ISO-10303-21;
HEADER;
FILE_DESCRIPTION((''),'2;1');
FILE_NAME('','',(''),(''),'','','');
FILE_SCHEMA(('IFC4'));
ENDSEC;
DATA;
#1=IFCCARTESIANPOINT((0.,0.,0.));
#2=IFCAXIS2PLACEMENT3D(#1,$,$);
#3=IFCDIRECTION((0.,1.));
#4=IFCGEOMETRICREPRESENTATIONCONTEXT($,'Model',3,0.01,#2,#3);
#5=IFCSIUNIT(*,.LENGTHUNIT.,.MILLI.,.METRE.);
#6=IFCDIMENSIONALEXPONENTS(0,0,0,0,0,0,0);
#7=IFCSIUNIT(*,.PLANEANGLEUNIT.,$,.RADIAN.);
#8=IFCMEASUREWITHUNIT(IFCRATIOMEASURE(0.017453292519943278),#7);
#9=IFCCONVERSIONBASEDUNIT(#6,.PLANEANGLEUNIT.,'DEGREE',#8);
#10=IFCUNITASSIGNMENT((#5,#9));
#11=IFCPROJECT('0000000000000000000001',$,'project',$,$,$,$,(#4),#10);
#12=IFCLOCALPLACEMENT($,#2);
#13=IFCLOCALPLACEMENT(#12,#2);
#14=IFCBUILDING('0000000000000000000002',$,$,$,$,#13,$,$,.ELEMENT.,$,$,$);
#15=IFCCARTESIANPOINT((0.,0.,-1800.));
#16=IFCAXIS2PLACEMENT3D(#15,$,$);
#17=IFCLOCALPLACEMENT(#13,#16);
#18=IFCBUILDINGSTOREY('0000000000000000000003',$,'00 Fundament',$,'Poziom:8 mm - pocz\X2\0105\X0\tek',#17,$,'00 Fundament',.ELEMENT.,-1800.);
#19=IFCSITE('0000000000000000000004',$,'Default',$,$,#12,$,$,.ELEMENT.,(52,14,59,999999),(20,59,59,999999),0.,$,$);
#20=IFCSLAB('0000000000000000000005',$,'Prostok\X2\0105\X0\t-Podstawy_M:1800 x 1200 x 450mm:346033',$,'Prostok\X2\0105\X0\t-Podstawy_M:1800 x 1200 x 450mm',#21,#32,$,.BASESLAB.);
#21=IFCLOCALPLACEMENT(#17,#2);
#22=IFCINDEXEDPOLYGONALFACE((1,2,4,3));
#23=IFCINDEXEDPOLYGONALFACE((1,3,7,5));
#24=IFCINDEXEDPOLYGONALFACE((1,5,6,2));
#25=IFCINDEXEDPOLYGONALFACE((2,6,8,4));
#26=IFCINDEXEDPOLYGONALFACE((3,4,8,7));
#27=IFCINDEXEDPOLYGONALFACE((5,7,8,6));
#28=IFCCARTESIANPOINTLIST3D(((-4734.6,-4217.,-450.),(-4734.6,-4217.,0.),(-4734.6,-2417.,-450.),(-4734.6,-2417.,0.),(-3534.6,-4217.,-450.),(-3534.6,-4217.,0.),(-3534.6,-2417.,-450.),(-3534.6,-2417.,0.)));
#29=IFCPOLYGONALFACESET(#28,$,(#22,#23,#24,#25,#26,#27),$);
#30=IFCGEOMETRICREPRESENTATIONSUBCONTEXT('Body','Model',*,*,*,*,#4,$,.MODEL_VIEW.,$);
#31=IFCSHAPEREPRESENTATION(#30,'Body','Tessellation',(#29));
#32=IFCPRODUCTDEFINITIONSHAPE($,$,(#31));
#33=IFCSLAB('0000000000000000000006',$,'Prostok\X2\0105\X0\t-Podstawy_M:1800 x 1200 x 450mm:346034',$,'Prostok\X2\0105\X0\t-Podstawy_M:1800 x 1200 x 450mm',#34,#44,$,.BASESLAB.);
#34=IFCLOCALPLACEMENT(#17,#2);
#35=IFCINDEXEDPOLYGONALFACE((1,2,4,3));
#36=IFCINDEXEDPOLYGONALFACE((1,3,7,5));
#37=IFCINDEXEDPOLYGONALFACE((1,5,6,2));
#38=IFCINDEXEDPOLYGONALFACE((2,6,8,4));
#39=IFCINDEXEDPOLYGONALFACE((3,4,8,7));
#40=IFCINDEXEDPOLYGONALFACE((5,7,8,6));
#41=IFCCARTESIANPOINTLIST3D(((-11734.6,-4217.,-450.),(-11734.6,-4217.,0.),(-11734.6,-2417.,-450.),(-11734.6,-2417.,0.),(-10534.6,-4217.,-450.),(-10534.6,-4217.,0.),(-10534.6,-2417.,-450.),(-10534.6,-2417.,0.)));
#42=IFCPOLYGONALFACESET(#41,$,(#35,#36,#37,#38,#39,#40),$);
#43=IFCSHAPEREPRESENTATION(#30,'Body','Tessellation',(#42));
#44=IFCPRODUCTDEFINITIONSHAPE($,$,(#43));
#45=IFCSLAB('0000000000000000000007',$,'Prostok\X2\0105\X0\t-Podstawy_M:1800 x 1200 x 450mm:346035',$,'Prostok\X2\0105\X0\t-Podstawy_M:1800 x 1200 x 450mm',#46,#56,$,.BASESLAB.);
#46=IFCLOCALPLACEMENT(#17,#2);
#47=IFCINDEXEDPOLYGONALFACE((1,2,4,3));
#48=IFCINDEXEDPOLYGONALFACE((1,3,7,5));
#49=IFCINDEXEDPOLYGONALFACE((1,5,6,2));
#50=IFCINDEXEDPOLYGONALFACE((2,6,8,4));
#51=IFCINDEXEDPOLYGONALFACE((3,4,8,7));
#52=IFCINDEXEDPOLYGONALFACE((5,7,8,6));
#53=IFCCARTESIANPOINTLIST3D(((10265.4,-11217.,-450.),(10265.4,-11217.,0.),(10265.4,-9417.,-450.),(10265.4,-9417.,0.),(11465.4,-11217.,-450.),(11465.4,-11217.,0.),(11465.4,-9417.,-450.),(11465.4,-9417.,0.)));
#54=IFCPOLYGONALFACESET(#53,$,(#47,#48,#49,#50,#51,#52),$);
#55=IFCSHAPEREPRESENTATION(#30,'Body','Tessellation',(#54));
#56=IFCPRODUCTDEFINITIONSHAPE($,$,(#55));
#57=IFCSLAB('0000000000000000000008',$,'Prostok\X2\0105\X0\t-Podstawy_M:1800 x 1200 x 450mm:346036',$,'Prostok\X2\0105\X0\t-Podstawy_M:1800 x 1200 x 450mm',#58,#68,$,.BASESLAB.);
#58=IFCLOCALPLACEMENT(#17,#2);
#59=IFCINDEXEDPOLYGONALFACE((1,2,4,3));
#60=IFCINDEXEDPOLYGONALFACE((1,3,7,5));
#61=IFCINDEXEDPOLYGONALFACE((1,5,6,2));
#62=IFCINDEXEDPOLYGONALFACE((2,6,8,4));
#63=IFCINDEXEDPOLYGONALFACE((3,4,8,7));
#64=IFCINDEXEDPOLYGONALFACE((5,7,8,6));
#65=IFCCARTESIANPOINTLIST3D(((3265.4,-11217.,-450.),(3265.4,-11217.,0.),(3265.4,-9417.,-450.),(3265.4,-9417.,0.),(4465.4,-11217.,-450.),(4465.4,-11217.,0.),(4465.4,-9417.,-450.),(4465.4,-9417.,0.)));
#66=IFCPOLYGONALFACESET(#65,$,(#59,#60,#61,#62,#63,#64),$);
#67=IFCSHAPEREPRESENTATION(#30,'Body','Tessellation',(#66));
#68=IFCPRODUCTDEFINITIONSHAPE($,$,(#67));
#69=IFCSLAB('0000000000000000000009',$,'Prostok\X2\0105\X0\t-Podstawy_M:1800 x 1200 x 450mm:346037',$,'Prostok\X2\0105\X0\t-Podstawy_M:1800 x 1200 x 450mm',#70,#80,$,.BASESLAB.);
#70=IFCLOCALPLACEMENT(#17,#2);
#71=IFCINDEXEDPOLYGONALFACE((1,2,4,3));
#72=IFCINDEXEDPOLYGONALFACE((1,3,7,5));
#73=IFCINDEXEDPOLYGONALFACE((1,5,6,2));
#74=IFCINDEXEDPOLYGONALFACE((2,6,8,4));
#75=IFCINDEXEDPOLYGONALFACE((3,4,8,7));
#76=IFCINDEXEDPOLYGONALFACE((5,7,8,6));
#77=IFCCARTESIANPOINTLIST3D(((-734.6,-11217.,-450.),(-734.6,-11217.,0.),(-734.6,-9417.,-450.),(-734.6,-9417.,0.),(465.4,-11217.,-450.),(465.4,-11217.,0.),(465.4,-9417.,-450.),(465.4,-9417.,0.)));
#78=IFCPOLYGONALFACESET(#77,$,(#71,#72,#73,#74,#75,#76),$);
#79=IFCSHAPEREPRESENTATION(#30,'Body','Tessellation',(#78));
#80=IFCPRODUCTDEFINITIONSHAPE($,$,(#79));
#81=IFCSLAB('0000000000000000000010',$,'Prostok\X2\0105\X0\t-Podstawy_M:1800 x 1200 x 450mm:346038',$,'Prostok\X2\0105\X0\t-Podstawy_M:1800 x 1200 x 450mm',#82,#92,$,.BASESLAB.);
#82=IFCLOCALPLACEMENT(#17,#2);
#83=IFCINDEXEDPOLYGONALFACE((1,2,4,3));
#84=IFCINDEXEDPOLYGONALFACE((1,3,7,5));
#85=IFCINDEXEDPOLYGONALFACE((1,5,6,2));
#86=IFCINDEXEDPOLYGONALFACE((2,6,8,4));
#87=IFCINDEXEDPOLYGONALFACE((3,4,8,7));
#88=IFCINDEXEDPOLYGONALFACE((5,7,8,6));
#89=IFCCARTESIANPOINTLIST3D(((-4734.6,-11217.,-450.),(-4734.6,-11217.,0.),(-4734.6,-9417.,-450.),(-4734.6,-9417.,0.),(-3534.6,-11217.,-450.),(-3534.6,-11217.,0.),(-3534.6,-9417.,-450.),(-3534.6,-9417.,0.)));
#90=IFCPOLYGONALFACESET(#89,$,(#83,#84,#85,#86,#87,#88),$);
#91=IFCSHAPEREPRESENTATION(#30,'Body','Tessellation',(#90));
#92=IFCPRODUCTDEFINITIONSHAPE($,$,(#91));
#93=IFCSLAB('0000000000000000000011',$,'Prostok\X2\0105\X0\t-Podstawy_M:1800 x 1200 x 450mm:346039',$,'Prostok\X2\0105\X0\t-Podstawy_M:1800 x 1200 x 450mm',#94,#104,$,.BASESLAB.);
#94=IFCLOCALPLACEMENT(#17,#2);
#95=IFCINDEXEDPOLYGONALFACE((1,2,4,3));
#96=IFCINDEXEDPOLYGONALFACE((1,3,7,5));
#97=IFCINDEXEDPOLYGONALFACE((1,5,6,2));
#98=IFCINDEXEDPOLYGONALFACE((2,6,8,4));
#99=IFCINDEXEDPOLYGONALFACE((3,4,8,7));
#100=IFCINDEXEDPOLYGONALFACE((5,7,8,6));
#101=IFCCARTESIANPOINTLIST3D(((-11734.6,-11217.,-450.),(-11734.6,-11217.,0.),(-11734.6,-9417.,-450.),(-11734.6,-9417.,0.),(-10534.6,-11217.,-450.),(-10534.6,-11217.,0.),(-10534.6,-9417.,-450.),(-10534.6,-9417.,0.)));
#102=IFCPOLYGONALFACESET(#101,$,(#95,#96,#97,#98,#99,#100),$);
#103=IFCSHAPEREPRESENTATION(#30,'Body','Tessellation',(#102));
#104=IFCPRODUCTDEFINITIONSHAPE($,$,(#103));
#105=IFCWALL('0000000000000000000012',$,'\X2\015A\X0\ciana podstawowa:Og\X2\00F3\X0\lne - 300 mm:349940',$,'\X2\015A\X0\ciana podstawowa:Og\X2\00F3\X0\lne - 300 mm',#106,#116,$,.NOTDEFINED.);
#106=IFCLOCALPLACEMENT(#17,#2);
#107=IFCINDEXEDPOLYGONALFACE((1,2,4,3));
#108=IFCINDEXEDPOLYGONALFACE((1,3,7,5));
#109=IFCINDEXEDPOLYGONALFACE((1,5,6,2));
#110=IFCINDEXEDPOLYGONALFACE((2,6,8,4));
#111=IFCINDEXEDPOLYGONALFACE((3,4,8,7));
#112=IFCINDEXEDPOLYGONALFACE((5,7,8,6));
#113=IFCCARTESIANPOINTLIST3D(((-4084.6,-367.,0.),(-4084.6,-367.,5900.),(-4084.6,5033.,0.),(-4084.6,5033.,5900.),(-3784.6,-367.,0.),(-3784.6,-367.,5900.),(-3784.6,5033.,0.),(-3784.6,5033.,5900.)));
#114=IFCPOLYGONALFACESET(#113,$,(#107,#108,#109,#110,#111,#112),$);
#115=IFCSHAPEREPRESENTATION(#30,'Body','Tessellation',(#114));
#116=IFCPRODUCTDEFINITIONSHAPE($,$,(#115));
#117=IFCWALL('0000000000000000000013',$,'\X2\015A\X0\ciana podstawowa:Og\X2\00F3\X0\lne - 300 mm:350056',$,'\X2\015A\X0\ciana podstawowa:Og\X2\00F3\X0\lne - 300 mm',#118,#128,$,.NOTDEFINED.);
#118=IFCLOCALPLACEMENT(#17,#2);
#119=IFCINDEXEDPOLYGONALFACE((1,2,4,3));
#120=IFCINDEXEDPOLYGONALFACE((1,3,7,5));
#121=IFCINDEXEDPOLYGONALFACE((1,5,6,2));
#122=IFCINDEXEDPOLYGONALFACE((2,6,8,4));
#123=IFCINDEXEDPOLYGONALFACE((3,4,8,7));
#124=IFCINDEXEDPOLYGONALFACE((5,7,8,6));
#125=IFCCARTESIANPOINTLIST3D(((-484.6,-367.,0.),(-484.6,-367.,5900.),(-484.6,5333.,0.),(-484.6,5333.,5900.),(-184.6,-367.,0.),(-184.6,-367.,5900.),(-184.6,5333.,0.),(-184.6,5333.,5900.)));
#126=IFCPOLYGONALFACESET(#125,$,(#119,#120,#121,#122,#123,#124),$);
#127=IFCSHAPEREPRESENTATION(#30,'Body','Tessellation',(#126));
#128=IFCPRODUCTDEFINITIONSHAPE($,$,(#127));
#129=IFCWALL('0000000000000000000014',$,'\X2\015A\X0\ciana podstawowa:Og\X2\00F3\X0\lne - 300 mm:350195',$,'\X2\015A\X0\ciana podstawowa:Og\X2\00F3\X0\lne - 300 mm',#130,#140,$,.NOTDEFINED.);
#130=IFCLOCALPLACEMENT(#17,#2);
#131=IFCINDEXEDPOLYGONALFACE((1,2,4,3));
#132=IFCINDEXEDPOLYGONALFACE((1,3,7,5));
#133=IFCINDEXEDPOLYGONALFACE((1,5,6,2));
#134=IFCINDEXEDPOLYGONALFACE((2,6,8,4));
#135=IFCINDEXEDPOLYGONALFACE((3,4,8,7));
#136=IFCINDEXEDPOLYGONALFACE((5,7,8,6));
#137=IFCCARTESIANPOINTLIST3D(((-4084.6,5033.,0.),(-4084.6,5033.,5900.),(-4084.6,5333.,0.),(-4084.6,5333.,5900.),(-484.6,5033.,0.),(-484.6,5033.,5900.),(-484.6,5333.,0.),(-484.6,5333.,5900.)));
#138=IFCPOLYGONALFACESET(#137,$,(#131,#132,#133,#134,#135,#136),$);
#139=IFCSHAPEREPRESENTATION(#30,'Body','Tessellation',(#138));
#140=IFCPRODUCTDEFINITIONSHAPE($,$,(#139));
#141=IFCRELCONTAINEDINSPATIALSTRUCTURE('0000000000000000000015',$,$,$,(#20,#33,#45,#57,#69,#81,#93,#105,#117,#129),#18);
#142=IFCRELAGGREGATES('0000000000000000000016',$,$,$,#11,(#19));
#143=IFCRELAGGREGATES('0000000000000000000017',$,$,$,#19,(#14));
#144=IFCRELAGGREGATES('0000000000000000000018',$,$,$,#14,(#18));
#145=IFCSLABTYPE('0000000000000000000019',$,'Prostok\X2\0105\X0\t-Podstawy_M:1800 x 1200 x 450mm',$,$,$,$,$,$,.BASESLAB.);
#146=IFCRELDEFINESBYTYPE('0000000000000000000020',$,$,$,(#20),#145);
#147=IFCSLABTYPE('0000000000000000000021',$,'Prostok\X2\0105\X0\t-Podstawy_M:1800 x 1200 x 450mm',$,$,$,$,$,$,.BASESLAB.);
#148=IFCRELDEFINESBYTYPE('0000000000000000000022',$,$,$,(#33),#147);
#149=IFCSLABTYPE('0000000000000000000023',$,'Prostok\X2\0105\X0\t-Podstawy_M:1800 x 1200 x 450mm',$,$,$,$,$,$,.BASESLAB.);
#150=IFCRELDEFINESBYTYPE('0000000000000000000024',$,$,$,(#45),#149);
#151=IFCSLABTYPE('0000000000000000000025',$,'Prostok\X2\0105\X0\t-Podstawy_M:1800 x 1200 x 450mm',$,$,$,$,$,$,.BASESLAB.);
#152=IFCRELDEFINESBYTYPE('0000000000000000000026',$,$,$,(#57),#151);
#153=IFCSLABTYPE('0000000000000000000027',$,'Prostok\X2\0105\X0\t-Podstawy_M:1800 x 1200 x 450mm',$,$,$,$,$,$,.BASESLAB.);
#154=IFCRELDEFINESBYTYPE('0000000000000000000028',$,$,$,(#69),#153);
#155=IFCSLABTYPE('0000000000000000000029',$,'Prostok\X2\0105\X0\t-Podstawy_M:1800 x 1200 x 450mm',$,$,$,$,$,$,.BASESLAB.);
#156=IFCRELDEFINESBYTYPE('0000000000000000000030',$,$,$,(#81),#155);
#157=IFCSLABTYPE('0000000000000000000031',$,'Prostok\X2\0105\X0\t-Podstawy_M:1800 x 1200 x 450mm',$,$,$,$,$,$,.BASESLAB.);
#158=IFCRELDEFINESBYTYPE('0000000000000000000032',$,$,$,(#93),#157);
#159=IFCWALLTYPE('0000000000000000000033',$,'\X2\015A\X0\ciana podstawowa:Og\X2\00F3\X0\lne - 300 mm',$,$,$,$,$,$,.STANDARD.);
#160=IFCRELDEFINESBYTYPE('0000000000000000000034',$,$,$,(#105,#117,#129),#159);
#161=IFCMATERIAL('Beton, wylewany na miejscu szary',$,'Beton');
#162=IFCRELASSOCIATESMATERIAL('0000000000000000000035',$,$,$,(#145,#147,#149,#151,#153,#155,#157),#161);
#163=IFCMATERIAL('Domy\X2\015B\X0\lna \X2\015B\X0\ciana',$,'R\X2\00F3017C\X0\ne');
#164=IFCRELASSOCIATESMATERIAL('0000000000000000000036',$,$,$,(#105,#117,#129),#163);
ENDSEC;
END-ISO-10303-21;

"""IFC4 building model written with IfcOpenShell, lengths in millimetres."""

from ifc_helpers import new_model, entity, si_unit, converted_unit, direction, frame, origin, place, context, subcontext, project, spatial, indexed_curve, outline, extrude, material, type_object, element, save


model = new_model("IFC4")

# Units and contexts
model_context = context("Model", 3, precision=0.01, world=origin(), true_north=direction((0.0, 1.0)))
body_context = subcontext(model_context, "Body", "Model", "MODEL_VIEW")
ifc_project = project(units=[si_unit("LENGTHUNIT", "METRE", prefix="MILLI"), converted_unit("PLANEANGLEUNIT", "DEGREE", entity("IfcRatioMeasure", 0.017453292519943278), si_unit("PLANEANGLEUNIT", "RADIAN"), dimensions=[0, 0, 0, 0, 0, 0, 0])], contexts=[model_context])

# Site, building, storey
site_placement = place(None, origin())
site = spatial("IfcSite", under=ifc_project, at=site_placement, Name="Default", CompositionType="ELEMENT", RefLatitude=(52, 14, 59, 999999), RefLongitude=(20, 59, 59, 999999), RefElevation=0.0)
building_placement = place(site_placement, origin())
building = spatial("IfcBuilding", under=site, at=building_placement, CompositionType="ELEMENT")
storey_placement = place(building_placement, frame((0.0, 0.0, -1800.0)))
storey = spatial("IfcBuildingStorey", under=building, at=storey_placement, Name="00 Fundament", ObjectType="Poziom:8 mm - początek", LongName="00 Fundament", CompositionType="ELEMENT", Elevation=-1800.0)

# Slabs
ifc_material_1 = material(Name="Beton, wylewany na miejscu szary", Category="Beton")
slab_type_1 = type_object("IfcSlabType", Name="Prostokąt-Podstawy_M:1800 x 1200 x 450mm", PredefinedType="BASESLAB", material=ifc_material_1)
slab_1_placement = place(storey_placement, origin())
element("IfcSlab", 1, at=slab_1_placement, inside=storey, type_object=slab_type_1, Name="Prostokąt-Podstawy_M:1800 x 1200 x 450mm:346033", ObjectType="Prostokąt-Podstawy_M:1800 x 1200 x 450mm", PredefinedType="BASESLAB", context=body_context, shape_type="SweptSolid", body=[
    extrude(outline(indexed_curve([(-600.0, -900.0), (600.0, -900.0), (600.0, 900.0), (-600.0, 900.0), (-600.0, -900.0)], self_intersect=False)), frame((-4134.6, -3317.0, -450.0), z_axis=(0.0, 0.0, 1.0), x_axis=(-1.0, 0.0, 0.0)), (0.0, 0.0, 1.0), 450.0),
])
slab_type_2 = type_object("IfcSlabType", Name="Prostokąt-Podstawy_M:1800 x 1200 x 450mm", PredefinedType="BASESLAB", material=ifc_material_1)
slab_2_placement = place(storey_placement, origin())
element("IfcSlab", 2, at=slab_2_placement, inside=storey, type_object=slab_type_2, Name="Prostokąt-Podstawy_M:1800 x 1200 x 450mm:346034", ObjectType="Prostokąt-Podstawy_M:1800 x 1200 x 450mm", PredefinedType="BASESLAB", context=body_context, shape_type="SweptSolid", body=[
    extrude(outline(indexed_curve([(-600.0, -900.0), (600.0, -900.0), (600.0, 900.0), (-600.0, 900.0), (-600.0, -900.0)], self_intersect=False)), frame((-11134.6, -3317.0, -450.0), z_axis=(0.0, 0.0, 1.0), x_axis=(-1.0, 0.0, 0.0)), (0.0, 0.0, 1.0), 450.0),
])
slab_type_3 = type_object("IfcSlabType", Name="Prostokąt-Podstawy_M:1800 x 1200 x 450mm", PredefinedType="BASESLAB", material=ifc_material_1)
slab_3_placement = place(storey_placement, origin())
element("IfcSlab", 3, at=slab_3_placement, inside=storey, type_object=slab_type_3, Name="Prostokąt-Podstawy_M:1800 x 1200 x 450mm:346035", ObjectType="Prostokąt-Podstawy_M:1800 x 1200 x 450mm", PredefinedType="BASESLAB", context=body_context, shape_type="SweptSolid", body=[
    extrude(outline(indexed_curve([(-600.0, -900.0), (600.0, -900.0), (600.0, 900.0), (-600.0, 900.0), (-600.0, -900.0)], self_intersect=False)), frame((10865.4, -10317.0, -450.0), z_axis=(0.0, 0.0, 1.0), x_axis=(-1.0, 0.0, 0.0)), (0.0, 0.0, 1.0), 450.0),
])
slab_type_4 = type_object("IfcSlabType", Name="Prostokąt-Podstawy_M:1800 x 1200 x 450mm", PredefinedType="BASESLAB", material=ifc_material_1)
slab_4_placement = place(storey_placement, origin())
element("IfcSlab", 4, at=slab_4_placement, inside=storey, type_object=slab_type_4, Name="Prostokąt-Podstawy_M:1800 x 1200 x 450mm:346036", ObjectType="Prostokąt-Podstawy_M:1800 x 1200 x 450mm", PredefinedType="BASESLAB", context=body_context, shape_type="SweptSolid", body=[
    extrude(outline(indexed_curve([(-600.0, -900.0), (600.0, -900.0), (600.0, 900.0), (-600.0, 900.0), (-600.0, -900.0)], self_intersect=False)), frame((3865.4, -10317.0, -450.0), z_axis=(0.0, 0.0, 1.0), x_axis=(-1.0, 0.0, 0.0)), (0.0, 0.0, 1.0), 450.0),
])
slab_type_5 = type_object("IfcSlabType", Name="Prostokąt-Podstawy_M:1800 x 1200 x 450mm", PredefinedType="BASESLAB", material=ifc_material_1)
slab_5_placement = place(storey_placement, origin())
element("IfcSlab", 5, at=slab_5_placement, inside=storey, type_object=slab_type_5, Name="Prostokąt-Podstawy_M:1800 x 1200 x 450mm:346037", ObjectType="Prostokąt-Podstawy_M:1800 x 1200 x 450mm", PredefinedType="BASESLAB", context=body_context, shape_type="SweptSolid", body=[
    extrude(outline(indexed_curve([(-600.0, -900.0), (600.0, -900.0), (600.0, 900.0), (-600.0, 900.0), (-600.0, -900.0)], self_intersect=False)), frame((-134.6, -10317.0, -450.0), z_axis=(0.0, 0.0, 1.0), x_axis=(-1.0, 0.0, 0.0)), (0.0, 0.0, 1.0), 450.0),
])
slab_type_6 = type_object("IfcSlabType", Name="Prostokąt-Podstawy_M:1800 x 1200 x 450mm", PredefinedType="BASESLAB", material=ifc_material_1)
slab_6_placement = place(storey_placement, origin())
element("IfcSlab", 6, at=slab_6_placement, inside=storey, type_object=slab_type_6, Name="Prostokąt-Podstawy_M:1800 x 1200 x 450mm:346038", ObjectType="Prostokąt-Podstawy_M:1800 x 1200 x 450mm", PredefinedType="BASESLAB", context=body_context, shape_type="SweptSolid", body=[
    extrude(outline(indexed_curve([(-600.0, -900.0), (600.0, -900.0), (600.0, 900.0), (-600.0, 900.0), (-600.0, -900.0)], self_intersect=False)), frame((-4134.6, -10317.0, -450.0), z_axis=(0.0, 0.0, 1.0), x_axis=(-1.0, 0.0, 0.0)), (0.0, 0.0, 1.0), 450.0),
])
slab_type_7 = type_object("IfcSlabType", Name="Prostokąt-Podstawy_M:1800 x 1200 x 450mm", PredefinedType="BASESLAB", material=ifc_material_1)
slab_7_placement = place(storey_placement, origin())
element("IfcSlab", 7, at=slab_7_placement, inside=storey, type_object=slab_type_7, Name="Prostokąt-Podstawy_M:1800 x 1200 x 450mm:346039", ObjectType="Prostokąt-Podstawy_M:1800 x 1200 x 450mm", PredefinedType="BASESLAB", context=body_context, shape_type="SweptSolid", body=[
    extrude(outline(indexed_curve([(-600.0, -900.0), (600.0, -900.0), (600.0, 900.0), (-600.0, 900.0), (-600.0, -900.0)], self_intersect=False)), frame((-11134.6, -10317.0, -450.0), z_axis=(0.0, 0.0, 1.0), x_axis=(-1.0, 0.0, 0.0)), (0.0, 0.0, 1.0), 450.0),
])

# Walls
ifc_material_2 = material(Name="Domyślna ściana", Category="Różne")
wall_type = type_object("IfcWallType", Name="Ściana podstawowa:Ogólne - 300 mm", PredefinedType="STANDARD")
wall_1_placement = place(storey_placement, frame((-3934.6, 5033.0, 0.0), z_axis=(0.0, 0.0, 1.0), x_axis=(0.0, -1.0, 0.0)))
element("IfcWall", 8, at=wall_1_placement, inside=storey, type_object=wall_type, material=ifc_material_2, Name="Ściana podstawowa:Ogólne - 300 mm:349940", ObjectType="Ściana podstawowa:Ogólne - 300 mm", PredefinedType="NOTDEFINED", context=body_context, shape_type="SweptSolid", body=[
    extrude(outline(indexed_curve([(5400.0, 150.0), (0.0, 150.0), (0.0, -150.0), (5400.0, -150.0), (5400.0, 150.0)], self_intersect=False)), origin(), (0.0, 0.0, 1.0), 5900.0),
])
wall_2_placement = place(storey_placement, frame((-334.6, 5333.0, 0.0), z_axis=(0.0, 0.0, 1.0), x_axis=(0.0, -1.0, 0.0)))
element("IfcWall", 9, at=wall_2_placement, inside=storey, type_object=wall_type, material=ifc_material_2, Name="Ściana podstawowa:Ogólne - 300 mm:350056", ObjectType="Ściana podstawowa:Ogólne - 300 mm", PredefinedType="NOTDEFINED", context=body_context, shape_type="SweptSolid", body=[
    extrude(outline(indexed_curve([(5700.0, 150.0), (0.0, 150.0), (0.0, -150.0), (5700.0, -150.0), (5700.0, 150.0)], self_intersect=False)), origin(), (0.0, 0.0, 1.0), 5900.0),
])
wall_3_placement = place(storey_placement, frame((-4084.6, 5183.0, 0.0)))
element("IfcWall", 10, at=wall_3_placement, inside=storey, type_object=wall_type, material=ifc_material_2, Name="Ściana podstawowa:Ogólne - 300 mm:350195", ObjectType="Ściana podstawowa:Ogólne - 300 mm", PredefinedType="NOTDEFINED", context=body_context, shape_type="SweptSolid", body=[
    extrude(outline(indexed_curve([(3600.0, 150.0), (0.0, 150.0), (0.0, -150.0), (3600.0, -150.0), (3600.0, 150.0)], self_intersect=False)), origin(), (0.0, 0.0, 1.0), 5900.0),
])

save(model, "model.ifc")
